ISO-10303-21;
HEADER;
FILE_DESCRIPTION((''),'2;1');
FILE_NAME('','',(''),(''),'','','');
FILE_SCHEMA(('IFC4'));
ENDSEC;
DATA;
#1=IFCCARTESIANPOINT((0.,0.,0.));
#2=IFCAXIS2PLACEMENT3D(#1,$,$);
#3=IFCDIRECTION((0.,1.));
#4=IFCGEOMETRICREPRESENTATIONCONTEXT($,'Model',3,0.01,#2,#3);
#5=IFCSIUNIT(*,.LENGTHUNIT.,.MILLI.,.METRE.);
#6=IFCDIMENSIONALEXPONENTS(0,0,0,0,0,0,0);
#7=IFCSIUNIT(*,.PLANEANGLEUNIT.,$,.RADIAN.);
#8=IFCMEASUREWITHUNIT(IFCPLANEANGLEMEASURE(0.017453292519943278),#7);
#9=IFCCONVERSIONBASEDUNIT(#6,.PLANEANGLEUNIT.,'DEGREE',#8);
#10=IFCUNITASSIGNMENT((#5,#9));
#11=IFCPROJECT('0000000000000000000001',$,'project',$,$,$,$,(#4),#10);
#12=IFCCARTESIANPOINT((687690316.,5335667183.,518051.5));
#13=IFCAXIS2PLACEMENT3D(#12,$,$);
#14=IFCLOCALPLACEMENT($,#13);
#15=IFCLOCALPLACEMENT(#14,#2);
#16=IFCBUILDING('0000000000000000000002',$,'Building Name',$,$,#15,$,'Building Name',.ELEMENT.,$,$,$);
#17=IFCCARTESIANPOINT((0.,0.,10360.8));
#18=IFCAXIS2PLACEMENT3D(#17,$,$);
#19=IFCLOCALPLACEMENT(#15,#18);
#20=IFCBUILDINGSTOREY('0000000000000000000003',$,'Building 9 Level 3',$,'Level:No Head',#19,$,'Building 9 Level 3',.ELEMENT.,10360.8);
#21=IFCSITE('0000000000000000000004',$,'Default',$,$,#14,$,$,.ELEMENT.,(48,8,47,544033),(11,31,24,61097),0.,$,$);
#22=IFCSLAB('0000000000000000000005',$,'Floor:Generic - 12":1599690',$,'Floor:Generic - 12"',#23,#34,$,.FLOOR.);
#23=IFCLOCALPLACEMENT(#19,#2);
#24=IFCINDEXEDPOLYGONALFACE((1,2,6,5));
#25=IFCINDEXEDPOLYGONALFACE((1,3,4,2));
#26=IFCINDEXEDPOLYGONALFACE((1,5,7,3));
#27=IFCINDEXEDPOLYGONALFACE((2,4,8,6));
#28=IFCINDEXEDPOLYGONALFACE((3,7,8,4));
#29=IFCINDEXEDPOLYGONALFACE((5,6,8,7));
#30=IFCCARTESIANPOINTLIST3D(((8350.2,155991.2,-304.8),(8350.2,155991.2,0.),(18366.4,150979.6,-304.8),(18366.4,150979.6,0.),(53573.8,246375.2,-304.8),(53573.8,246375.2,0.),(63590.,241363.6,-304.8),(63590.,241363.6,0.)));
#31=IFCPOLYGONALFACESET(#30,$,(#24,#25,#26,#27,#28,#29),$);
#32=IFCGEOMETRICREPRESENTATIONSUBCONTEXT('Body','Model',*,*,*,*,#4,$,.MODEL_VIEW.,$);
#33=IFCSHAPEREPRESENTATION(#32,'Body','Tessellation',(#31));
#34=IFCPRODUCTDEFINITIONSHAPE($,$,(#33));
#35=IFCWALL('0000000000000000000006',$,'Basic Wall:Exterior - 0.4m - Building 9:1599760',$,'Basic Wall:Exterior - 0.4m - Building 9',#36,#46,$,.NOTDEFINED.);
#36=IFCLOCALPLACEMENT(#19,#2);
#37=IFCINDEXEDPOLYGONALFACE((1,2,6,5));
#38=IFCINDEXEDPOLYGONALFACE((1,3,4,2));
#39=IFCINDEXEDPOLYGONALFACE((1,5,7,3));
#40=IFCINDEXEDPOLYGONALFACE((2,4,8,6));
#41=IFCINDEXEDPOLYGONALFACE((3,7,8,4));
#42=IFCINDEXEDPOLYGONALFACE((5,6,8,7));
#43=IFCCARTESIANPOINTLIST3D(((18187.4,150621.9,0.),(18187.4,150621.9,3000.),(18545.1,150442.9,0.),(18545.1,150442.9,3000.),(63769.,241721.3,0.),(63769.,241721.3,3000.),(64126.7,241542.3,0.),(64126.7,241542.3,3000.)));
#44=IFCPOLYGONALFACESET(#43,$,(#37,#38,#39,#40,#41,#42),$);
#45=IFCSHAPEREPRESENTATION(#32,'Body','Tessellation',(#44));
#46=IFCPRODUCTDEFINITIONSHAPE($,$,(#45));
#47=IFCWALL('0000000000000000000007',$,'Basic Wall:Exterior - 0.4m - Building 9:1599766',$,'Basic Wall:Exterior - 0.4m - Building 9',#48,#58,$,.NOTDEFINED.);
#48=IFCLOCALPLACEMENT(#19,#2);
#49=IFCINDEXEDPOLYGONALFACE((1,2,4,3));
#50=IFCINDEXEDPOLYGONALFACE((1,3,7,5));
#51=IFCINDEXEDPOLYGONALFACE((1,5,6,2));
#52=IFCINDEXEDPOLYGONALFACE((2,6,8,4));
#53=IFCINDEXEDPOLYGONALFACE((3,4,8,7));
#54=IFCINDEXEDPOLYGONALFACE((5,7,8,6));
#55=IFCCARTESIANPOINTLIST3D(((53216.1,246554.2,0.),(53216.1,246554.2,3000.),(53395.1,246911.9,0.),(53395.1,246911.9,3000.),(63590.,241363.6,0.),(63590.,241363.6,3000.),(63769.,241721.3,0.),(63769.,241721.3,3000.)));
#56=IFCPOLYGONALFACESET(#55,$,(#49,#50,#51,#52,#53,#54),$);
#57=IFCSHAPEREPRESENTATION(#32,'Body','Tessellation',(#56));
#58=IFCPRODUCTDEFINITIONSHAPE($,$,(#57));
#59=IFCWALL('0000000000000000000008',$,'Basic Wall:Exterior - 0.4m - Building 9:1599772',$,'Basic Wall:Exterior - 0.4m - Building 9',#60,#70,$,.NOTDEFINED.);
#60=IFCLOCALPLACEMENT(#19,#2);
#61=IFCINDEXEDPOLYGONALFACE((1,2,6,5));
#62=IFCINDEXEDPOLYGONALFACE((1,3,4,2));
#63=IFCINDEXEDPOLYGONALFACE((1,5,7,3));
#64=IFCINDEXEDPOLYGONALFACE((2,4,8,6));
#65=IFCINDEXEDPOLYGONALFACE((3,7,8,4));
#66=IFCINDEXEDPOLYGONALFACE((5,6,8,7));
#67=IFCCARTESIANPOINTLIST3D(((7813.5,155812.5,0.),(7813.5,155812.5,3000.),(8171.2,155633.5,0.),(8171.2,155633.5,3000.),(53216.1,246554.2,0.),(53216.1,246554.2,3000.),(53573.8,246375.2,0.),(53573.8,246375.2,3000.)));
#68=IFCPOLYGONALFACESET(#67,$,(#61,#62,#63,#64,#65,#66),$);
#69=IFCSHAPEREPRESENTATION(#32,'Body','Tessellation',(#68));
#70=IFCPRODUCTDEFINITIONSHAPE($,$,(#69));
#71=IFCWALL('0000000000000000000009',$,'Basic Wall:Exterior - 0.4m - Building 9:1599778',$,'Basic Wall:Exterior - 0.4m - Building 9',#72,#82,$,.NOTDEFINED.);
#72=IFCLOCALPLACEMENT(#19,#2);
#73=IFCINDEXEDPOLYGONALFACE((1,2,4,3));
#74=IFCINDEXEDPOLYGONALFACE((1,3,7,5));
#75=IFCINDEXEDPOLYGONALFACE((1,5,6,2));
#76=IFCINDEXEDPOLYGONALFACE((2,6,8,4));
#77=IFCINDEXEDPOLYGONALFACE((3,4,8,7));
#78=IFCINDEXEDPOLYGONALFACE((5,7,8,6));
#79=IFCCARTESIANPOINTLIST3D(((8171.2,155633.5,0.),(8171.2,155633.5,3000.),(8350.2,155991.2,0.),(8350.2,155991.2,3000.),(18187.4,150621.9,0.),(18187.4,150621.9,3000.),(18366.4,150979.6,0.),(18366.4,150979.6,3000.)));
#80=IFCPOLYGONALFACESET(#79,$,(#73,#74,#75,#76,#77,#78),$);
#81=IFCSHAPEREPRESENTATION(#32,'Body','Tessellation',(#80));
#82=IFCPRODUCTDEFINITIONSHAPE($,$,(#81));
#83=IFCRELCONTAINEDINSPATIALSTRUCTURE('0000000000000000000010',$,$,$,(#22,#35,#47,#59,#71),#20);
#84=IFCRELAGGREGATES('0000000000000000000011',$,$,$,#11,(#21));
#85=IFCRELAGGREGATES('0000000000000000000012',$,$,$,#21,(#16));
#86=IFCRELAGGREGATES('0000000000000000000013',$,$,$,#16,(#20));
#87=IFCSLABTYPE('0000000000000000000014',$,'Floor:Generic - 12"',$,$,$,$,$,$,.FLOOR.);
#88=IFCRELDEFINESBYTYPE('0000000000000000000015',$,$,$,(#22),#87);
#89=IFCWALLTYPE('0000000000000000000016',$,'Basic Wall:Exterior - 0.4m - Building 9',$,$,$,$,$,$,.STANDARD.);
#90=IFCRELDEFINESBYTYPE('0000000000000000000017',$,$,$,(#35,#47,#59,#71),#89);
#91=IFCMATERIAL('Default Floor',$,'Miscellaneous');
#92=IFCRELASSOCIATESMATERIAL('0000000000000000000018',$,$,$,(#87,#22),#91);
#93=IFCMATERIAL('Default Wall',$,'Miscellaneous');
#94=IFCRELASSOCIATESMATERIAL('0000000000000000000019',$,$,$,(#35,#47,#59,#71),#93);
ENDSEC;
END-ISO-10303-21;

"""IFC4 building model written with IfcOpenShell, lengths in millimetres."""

from ifc_helpers import new_model, entity, si_unit, converted_unit, direction, frame, origin, place, context, subcontext, project, spatial, indexed_curve, outline, extrude, material, type_object, element, save


model = new_model("IFC4")

# Units and contexts
model_context = context("Model", 3, precision=0.01, world=origin(), true_north=direction((0.0, 1.0)))
body_context = subcontext(model_context, "Body", "Model", "MODEL_VIEW")
ifc_project = project(units=[si_unit("LENGTHUNIT", "METRE", prefix="MILLI"), converted_unit("PLANEANGLEUNIT", "DEGREE", entity("IfcPlaneAngleMeasure", 0.017453292519943278), si_unit("PLANEANGLEUNIT", "RADIAN"), dimensions=[0, 0, 0, 0, 0, 0, 0])], contexts=[model_context])

# Site, building, storey
site_placement = place(None, frame((687690316.0, 5335667183.0, 518051.5)))
site = spatial("IfcSite", under=ifc_project, at=site_placement, Name="Default", CompositionType="ELEMENT", RefLatitude=(48, 8, 47, 544033), RefLongitude=(11, 31, 24, 61097), RefElevation=0.0)
building_placement = place(site_placement, origin())
building = spatial("IfcBuilding", under=site, at=building_placement, Name="Building Name", LongName="Building Name", CompositionType="ELEMENT")
storey_placement = place(building_placement, frame((0.0, 0.0, 10360.8)))
storey = spatial("IfcBuildingStorey", under=building, at=storey_placement, Name="Building 9 Level 3", ObjectType="Level:No Head", LongName="Building 9 Level 3", CompositionType="ELEMENT", Elevation=10360.8)

# Slab
ifc_material_1 = material(Name="Default Floor", Category="Miscellaneous")
slab_type = type_object("IfcSlabType", Name="Floor:Generic - 12\"", PredefinedType="FLOOR", material=ifc_material_1)
slab_placement = place(storey_placement, origin())
element("IfcSlab", 1, at=slab_placement, inside=storey, type_object=slab_type, material=ifc_material_1, Name="Floor:Generic - 12\":1599690", ObjectType="Floor:Generic - 12\"", PredefinedType="FLOOR", context=body_context, shape_type="SweptSolid", body=[
    extrude(outline(indexed_curve([(-50533.2, -5600.0), (50533.2, -5600.0), (50533.2, 5600.0), (-50533.2, 5600.0), (-50533.2, -5600.0)], self_intersect=False)), frame((35970.1, 198677.4, 0.0), z_axis=(0.0, 0.0, -1.0), x_axis=(-0.447464, -0.894302, 0.0)), (0.0, 0.0, 1.0), 304.8),
])

# Walls
ifc_material_2 = material(Name="Default Wall", Category="Miscellaneous")
wall_type = type_object("IfcWallType", Name="Basic Wall:Exterior - 0.4m - Building 9", PredefinedType="STANDARD")
wall_1_placement = place(storey_placement, frame((18366.3, 150532.4, 0.0), z_axis=(0.0, 0.0, 1.0), x_axis=(0.447464, 0.894302, 0.0)))
element("IfcWall", 2, at=wall_1_placement, inside=storey, type_object=wall_type, material=ifc_material_2, Name="Basic Wall:Exterior - 0.4m - Building 9:1599760", ObjectType="Basic Wall:Exterior - 0.4m - Building 9", PredefinedType="NOTDEFINED", context=body_context, shape_type="SweptSolid", body=[
    extrude(outline(indexed_curve([(101866.5, 200.0), (0.0, 200.0), (0.0, -200.0), (101866.5, -200.0), (101866.5, 200.0)], self_intersect=False)), origin(), (0.0, 0.0, 1.0), 3000.0),
])
wall_2_placement = place(storey_placement, frame((63679.5, 241542.5, 0.0), z_axis=(0.0, 0.0, 1.0), x_axis=(-0.894302, 0.447464, 0.0)))
element("IfcWall", 3, at=wall_2_placement, inside=storey, type_object=wall_type, material=ifc_material_2, Name="Basic Wall:Exterior - 0.4m - Building 9:1599766", ObjectType="Basic Wall:Exterior - 0.4m - Building 9", PredefinedType="NOTDEFINED", context=body_context, shape_type="SweptSolid", body=[
    extrude(outline(indexed_curve([(11600.0, 200.0), (0.0, 200.0), (0.0, -200.0), (11600.0, -200.0), (11600.0, 200.0)], self_intersect=False)), origin(), (0.0, 0.0, 1.0), 3000.0),
])
wall_3_placement = place(storey_placement, frame((53395.0, 246464.7, 0.0), z_axis=(0.0, 0.0, 1.0), x_axis=(-0.447464, -0.894302, 0.0)))
element("IfcWall", 4, at=wall_3_placement, inside=storey, type_object=wall_type, material=ifc_material_2, Name="Basic Wall:Exterior - 0.4m - Building 9:1599772", ObjectType="Basic Wall:Exterior - 0.4m - Building 9", PredefinedType="NOTDEFINED", context=body_context, shape_type="SweptSolid", body=[
    extrude(outline(indexed_curve([(101466.5, 200.0), (0.0, 200.0), (0.0, -200.0), (101466.5, -200.0), (101466.5, 200.0)], self_intersect=False)), origin(), (0.0, 0.0, 1.0), 3000.0),
])
wall_4_placement = place(storey_placement, frame((8260.7, 155812.4, 0.0), z_axis=(0.0, 0.0, 1.0), x_axis=(0.894302, -0.447464, 0.0)))
element("IfcWall", 5, at=wall_4_placement, inside=storey, type_object=wall_type, material=ifc_material_2, Name="Basic Wall:Exterior - 0.4m - Building 9:1599778", ObjectType="Basic Wall:Exterior - 0.4m - Building 9", PredefinedType="NOTDEFINED", context=body_context, shape_type="SweptSolid", body=[
    extrude(outline(indexed_curve([(11200.0, 200.0), (0.0, 200.0), (0.0, -200.0), (11200.0, -200.0), (11200.0, 200.0)], self_intersect=False)), origin(), (0.0, 0.0, 1.0), 3000.0),
])

save(model, "model.ifc")
